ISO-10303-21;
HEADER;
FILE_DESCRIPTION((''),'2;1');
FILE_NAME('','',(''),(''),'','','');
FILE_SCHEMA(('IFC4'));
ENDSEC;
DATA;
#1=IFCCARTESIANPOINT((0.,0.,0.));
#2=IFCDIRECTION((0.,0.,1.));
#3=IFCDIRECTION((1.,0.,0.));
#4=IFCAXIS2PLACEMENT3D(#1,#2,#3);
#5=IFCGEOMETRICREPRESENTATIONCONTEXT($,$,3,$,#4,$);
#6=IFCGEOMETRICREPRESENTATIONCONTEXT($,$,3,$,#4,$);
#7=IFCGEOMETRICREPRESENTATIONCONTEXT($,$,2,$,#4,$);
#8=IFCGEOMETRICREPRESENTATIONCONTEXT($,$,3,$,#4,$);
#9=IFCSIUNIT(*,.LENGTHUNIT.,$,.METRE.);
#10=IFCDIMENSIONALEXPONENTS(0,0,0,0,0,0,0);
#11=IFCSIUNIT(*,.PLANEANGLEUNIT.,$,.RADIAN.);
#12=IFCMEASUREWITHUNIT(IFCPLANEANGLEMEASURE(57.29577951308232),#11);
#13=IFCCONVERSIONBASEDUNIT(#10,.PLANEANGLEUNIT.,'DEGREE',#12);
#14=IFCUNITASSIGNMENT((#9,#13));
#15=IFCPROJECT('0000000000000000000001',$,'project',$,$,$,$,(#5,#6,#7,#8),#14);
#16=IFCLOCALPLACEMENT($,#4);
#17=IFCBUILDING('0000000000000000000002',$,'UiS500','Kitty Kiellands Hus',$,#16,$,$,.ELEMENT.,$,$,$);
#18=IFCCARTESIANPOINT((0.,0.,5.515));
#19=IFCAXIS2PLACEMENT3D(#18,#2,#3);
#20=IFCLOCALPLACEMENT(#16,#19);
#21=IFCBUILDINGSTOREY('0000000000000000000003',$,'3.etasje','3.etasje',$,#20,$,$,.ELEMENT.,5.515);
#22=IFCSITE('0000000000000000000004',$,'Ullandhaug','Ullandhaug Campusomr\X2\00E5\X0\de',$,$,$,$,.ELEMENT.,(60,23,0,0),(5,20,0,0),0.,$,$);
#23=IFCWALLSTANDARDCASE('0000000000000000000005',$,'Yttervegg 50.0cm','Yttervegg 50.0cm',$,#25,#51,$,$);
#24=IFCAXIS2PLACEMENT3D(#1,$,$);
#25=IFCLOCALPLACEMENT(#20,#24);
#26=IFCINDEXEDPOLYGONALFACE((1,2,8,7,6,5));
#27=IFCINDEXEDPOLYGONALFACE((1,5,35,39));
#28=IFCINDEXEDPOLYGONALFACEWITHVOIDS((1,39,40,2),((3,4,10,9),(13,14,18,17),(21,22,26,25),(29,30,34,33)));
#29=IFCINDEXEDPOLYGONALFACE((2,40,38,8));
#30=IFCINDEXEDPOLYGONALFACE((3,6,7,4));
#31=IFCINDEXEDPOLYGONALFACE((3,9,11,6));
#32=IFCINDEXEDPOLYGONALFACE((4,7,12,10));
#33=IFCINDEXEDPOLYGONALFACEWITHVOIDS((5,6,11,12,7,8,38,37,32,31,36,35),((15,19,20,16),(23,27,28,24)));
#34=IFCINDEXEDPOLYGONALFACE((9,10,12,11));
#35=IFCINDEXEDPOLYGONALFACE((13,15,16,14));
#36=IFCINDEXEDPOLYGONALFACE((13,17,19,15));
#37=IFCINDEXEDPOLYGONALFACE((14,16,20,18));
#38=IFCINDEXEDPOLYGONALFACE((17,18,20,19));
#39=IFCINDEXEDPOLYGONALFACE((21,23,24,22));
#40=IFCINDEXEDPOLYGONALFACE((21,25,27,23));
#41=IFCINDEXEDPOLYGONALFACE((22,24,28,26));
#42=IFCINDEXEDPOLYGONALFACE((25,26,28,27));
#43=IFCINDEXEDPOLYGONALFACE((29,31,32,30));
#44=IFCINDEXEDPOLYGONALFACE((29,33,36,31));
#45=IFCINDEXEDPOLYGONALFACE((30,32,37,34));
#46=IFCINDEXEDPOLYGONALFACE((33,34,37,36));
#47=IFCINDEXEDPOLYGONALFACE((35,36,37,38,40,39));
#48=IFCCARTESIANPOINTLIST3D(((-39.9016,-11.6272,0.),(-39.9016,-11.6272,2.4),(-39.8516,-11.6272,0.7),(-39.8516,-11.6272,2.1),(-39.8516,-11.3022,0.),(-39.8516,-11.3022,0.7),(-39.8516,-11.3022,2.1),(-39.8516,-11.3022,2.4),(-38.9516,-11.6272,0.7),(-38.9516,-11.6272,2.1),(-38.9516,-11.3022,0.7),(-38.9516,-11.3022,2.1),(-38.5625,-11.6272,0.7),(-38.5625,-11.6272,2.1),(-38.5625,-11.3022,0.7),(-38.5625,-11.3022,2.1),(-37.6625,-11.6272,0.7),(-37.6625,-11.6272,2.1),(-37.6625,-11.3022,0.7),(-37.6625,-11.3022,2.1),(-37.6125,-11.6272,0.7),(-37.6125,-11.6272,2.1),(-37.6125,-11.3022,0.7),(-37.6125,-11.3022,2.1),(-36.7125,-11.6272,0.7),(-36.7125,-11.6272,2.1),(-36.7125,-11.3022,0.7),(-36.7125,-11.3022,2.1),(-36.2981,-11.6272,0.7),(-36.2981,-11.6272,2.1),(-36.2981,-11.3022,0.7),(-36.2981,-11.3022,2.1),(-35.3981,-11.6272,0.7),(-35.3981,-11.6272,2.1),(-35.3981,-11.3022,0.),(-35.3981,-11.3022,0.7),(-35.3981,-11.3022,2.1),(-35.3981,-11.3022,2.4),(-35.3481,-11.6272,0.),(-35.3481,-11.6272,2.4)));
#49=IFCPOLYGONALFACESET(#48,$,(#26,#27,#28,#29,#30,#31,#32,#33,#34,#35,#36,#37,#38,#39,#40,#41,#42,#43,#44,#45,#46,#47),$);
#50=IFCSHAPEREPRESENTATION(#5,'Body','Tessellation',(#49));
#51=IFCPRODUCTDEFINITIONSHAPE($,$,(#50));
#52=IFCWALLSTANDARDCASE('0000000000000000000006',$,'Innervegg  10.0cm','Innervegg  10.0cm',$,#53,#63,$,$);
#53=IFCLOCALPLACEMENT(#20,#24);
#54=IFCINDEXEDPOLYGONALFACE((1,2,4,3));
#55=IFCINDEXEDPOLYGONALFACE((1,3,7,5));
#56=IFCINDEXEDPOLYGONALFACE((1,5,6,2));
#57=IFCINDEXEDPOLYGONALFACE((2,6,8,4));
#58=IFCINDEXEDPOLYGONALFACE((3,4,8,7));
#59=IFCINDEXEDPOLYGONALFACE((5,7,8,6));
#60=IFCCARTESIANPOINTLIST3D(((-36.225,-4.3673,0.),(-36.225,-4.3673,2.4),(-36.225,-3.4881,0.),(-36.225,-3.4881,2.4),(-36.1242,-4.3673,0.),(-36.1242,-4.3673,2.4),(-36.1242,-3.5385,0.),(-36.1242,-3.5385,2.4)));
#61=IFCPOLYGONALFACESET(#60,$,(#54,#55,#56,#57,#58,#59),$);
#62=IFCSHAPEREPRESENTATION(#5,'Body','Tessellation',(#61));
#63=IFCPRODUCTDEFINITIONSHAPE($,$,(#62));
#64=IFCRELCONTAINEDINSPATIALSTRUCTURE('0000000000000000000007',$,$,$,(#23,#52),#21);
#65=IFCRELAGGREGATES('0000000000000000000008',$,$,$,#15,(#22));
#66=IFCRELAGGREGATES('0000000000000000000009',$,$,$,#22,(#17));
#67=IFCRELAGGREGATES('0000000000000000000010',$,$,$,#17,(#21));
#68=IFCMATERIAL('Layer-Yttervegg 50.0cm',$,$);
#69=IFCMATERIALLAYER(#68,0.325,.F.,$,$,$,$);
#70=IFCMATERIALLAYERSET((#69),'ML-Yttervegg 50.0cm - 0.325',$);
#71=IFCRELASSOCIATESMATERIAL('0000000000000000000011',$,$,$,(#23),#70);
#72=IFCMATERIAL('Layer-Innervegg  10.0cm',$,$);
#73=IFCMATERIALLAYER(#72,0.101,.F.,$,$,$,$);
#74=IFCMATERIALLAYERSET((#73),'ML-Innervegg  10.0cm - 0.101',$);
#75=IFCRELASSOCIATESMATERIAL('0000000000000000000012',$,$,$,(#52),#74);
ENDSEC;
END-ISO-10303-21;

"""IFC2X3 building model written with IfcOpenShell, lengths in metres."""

from ifc_helpers import new_model, entity, si_unit, converted_unit, frame, origin_with_axes, place, context, project, spatial, polyline, outline, extrude, material, layer, layer_set, layer_usage, element, save


model = new_model("IFC2X3")

# Units and contexts
context_of_model_1 = context(None, 3, world=origin_with_axes())
context_of_model_2 = context(None, 3, world=origin_with_axes())
context_of_model_3 = context(None, 2, world=origin_with_axes())
context_of_model_4 = context(None, 3, world=origin_with_axes())
ifc_project = project(units=[si_unit("LENGTHUNIT", "METRE"), converted_unit("PLANEANGLEUNIT", "DEGREE", entity("IfcPlaneAngleMeasure", 57.29577951308232), si_unit("PLANEANGLEUNIT", "RADIAN"), dimensions=[0, 0, 0, 0, 0, 0, 0])], contexts=[context_of_model_1, context_of_model_2, context_of_model_3, context_of_model_4])

# Site, building, storey
site = spatial("IfcSite", under=ifc_project, Name="Ullandhaug", Description="Ullandhaug Campusområde", CompositionType="ELEMENT", RefLatitude=(60, 23, 0, 0), RefLongitude=(5, 20, 0, 0), RefElevation=0.0)
building_placement = place(None, origin_with_axes())
building = spatial("IfcBuilding", under=site, at=building_placement, Name="UiS500", Description="Kitty Kiellands Hus", CompositionType="ELEMENT")
storey_placement = place(building_placement, frame((0.0, 0.0, 5.515), z_axis=(0.0, 0.0, 1.0), x_axis=(1.0, 0.0, 0.0)))
storey = spatial("IfcBuildingStorey", under=building, at=storey_placement, Name="3.etasje", Description="3.etasje", CompositionType="ELEMENT", Elevation=5.515)

# Shared definitions
ifc_material_1 = material(Name="Layer-Yttervegg 50.0cm")
ifc_layer_1 = layer(ifc_material_1, 0.325, ventilated=False)
ifc_layer_set_1 = layer_set([ifc_layer_1], Name="ML-Yttervegg 50.0cm - 0.325")
ifc_layer_usage_1 = layer_usage(ifc_layer_set_1, "AXIS2", "POSITIVE", 0.0)

# Wall, openings
wall_1_placement = place(storey_placement, frame((-39.9016, -11.6272, 0.0), z_axis=(0.0, 0.0, 1.0), x_axis=(1.0, 0.0, 0.0)))
wall_1 = element("IfcWallStandardCase", 1, at=wall_1_placement, inside=storey, material=ifc_layer_usage_1, Name="Yttervegg 50.0cm", Description="Yttervegg 50.0cm", context=context_of_model_1, shape_type="SweptSolid", body=[
    extrude(outline(polyline([(0.0, 0.0), (4.5535, 0.0), (4.5035, 0.325), (0.05, 0.325), (0.0, 0.0)])), origin_with_axes(), (0.0, 0.0, 1.0), 2.4),
])
opening_1_placement = place(wall_1_placement, frame((0.05, 0.325, 0.7), z_axis=(0.0, 0.0, 1.0), x_axis=(1.0, 0.0, 0.0)))
element("IfcOpeningElement", 2, at=opening_1_placement, cuts=wall_1, context=context_of_model_1, shape_type="SweptSolid", body=[
    extrude(outline(polyline([(0.0, 0.0), (1.4, 0.0), (1.4, 0.9), (0.0, 0.9), (0.0, 0.0)])), frame((0.0, 0.0, 0.0), z_axis=(0.0, 1.0, 0.0), x_axis=(0.0, 0.0, 1.0)), (0.0, 0.0, -1.0), 0.325),
])
opening_2_placement = place(wall_1_placement, frame((1.3391, 0.325, 0.7), z_axis=(0.0, 0.0, 1.0), x_axis=(1.0, 0.0, 0.0)))
element("IfcOpeningElement", 3, at=opening_2_placement, cuts=wall_1, context=context_of_model_1, shape_type="SweptSolid", body=[
    extrude(outline(polyline([(0.0, 0.0), (1.4, 0.0), (1.4, 0.9), (0.0, 0.9), (0.0, 0.0)])), frame((0.0, 0.0, 0.0), z_axis=(0.0, 1.0, 0.0), x_axis=(0.0, 0.0, 1.0)), (0.0, 0.0, -1.0), 0.325),
])
opening_3_placement = place(wall_1_placement, frame((2.2891, 0.325, 0.7), z_axis=(0.0, 0.0, 1.0), x_axis=(1.0, 0.0, 0.0)))
element("IfcOpeningElement", 4, at=opening_3_placement, cuts=wall_1, context=context_of_model_1, shape_type="SweptSolid", body=[
    extrude(outline(polyline([(0.0, 0.0), (1.4, 0.0), (1.4, 0.9), (0.0, 0.9), (0.0, 0.0)])), frame((0.0, 0.0, 0.0), z_axis=(0.0, 1.0, 0.0), x_axis=(0.0, 0.0, 1.0)), (0.0, 0.0, -1.0), 0.325),
])
opening_4_placement = place(wall_1_placement, frame((3.6035, 0.325, 0.7), z_axis=(0.0, 0.0, 1.0), x_axis=(1.0, 0.0, 0.0)))
element("IfcOpeningElement", 5, at=opening_4_placement, cuts=wall_1, context=context_of_model_1, shape_type="SweptSolid", body=[
    extrude(outline(polyline([(0.0, 0.0), (1.4, 0.0), (1.4, 0.9), (0.0, 0.9), (0.0, 0.0)])), frame((0.0, 0.0, 0.0), z_axis=(0.0, 1.0, 0.0), x_axis=(0.0, 0.0, 1.0)), (0.0, 0.0, -1.0), 0.325),
])

# Wall
ifc_material_2 = material(Name="Layer-Innervegg  10.0cm")
ifc_layer_2 = layer(ifc_material_2, 0.101, ventilated=False)
ifc_layer_set_2 = layer_set([ifc_layer_2], Name="ML-Innervegg  10.0cm - 0.101")
ifc_layer_usage_2 = layer_usage(ifc_layer_set_2, "AXIS2", "POSITIVE", 0.0)
wall_2_placement = place(storey_placement, frame((-36.1242, -4.3673, 0.0), z_axis=(0.0, 0.0, 1.0), x_axis=(0.0, 1.0, 0.0)))
element("IfcWallStandardCase", 6, at=wall_2_placement, inside=storey, material=ifc_layer_usage_2, Name="Innervegg  10.0cm", Description="Innervegg  10.0cm", context=context_of_model_1, shape_type="SweptSolid", body=[
    extrude(outline(polyline([(0.0, 0.0), (0.8288, 0.0), (0.8792, 0.1008), (0.0, 0.1008), (0.0, 0.0)])), frame((0.0, 0.0, 0.0), z_axis=(0.0, 0.0, 1.0), x_axis=(1.0, 0.0, 0.0)), (0.0, 0.0, 1.0), 2.4),
])

save(model, "model.ifc")
